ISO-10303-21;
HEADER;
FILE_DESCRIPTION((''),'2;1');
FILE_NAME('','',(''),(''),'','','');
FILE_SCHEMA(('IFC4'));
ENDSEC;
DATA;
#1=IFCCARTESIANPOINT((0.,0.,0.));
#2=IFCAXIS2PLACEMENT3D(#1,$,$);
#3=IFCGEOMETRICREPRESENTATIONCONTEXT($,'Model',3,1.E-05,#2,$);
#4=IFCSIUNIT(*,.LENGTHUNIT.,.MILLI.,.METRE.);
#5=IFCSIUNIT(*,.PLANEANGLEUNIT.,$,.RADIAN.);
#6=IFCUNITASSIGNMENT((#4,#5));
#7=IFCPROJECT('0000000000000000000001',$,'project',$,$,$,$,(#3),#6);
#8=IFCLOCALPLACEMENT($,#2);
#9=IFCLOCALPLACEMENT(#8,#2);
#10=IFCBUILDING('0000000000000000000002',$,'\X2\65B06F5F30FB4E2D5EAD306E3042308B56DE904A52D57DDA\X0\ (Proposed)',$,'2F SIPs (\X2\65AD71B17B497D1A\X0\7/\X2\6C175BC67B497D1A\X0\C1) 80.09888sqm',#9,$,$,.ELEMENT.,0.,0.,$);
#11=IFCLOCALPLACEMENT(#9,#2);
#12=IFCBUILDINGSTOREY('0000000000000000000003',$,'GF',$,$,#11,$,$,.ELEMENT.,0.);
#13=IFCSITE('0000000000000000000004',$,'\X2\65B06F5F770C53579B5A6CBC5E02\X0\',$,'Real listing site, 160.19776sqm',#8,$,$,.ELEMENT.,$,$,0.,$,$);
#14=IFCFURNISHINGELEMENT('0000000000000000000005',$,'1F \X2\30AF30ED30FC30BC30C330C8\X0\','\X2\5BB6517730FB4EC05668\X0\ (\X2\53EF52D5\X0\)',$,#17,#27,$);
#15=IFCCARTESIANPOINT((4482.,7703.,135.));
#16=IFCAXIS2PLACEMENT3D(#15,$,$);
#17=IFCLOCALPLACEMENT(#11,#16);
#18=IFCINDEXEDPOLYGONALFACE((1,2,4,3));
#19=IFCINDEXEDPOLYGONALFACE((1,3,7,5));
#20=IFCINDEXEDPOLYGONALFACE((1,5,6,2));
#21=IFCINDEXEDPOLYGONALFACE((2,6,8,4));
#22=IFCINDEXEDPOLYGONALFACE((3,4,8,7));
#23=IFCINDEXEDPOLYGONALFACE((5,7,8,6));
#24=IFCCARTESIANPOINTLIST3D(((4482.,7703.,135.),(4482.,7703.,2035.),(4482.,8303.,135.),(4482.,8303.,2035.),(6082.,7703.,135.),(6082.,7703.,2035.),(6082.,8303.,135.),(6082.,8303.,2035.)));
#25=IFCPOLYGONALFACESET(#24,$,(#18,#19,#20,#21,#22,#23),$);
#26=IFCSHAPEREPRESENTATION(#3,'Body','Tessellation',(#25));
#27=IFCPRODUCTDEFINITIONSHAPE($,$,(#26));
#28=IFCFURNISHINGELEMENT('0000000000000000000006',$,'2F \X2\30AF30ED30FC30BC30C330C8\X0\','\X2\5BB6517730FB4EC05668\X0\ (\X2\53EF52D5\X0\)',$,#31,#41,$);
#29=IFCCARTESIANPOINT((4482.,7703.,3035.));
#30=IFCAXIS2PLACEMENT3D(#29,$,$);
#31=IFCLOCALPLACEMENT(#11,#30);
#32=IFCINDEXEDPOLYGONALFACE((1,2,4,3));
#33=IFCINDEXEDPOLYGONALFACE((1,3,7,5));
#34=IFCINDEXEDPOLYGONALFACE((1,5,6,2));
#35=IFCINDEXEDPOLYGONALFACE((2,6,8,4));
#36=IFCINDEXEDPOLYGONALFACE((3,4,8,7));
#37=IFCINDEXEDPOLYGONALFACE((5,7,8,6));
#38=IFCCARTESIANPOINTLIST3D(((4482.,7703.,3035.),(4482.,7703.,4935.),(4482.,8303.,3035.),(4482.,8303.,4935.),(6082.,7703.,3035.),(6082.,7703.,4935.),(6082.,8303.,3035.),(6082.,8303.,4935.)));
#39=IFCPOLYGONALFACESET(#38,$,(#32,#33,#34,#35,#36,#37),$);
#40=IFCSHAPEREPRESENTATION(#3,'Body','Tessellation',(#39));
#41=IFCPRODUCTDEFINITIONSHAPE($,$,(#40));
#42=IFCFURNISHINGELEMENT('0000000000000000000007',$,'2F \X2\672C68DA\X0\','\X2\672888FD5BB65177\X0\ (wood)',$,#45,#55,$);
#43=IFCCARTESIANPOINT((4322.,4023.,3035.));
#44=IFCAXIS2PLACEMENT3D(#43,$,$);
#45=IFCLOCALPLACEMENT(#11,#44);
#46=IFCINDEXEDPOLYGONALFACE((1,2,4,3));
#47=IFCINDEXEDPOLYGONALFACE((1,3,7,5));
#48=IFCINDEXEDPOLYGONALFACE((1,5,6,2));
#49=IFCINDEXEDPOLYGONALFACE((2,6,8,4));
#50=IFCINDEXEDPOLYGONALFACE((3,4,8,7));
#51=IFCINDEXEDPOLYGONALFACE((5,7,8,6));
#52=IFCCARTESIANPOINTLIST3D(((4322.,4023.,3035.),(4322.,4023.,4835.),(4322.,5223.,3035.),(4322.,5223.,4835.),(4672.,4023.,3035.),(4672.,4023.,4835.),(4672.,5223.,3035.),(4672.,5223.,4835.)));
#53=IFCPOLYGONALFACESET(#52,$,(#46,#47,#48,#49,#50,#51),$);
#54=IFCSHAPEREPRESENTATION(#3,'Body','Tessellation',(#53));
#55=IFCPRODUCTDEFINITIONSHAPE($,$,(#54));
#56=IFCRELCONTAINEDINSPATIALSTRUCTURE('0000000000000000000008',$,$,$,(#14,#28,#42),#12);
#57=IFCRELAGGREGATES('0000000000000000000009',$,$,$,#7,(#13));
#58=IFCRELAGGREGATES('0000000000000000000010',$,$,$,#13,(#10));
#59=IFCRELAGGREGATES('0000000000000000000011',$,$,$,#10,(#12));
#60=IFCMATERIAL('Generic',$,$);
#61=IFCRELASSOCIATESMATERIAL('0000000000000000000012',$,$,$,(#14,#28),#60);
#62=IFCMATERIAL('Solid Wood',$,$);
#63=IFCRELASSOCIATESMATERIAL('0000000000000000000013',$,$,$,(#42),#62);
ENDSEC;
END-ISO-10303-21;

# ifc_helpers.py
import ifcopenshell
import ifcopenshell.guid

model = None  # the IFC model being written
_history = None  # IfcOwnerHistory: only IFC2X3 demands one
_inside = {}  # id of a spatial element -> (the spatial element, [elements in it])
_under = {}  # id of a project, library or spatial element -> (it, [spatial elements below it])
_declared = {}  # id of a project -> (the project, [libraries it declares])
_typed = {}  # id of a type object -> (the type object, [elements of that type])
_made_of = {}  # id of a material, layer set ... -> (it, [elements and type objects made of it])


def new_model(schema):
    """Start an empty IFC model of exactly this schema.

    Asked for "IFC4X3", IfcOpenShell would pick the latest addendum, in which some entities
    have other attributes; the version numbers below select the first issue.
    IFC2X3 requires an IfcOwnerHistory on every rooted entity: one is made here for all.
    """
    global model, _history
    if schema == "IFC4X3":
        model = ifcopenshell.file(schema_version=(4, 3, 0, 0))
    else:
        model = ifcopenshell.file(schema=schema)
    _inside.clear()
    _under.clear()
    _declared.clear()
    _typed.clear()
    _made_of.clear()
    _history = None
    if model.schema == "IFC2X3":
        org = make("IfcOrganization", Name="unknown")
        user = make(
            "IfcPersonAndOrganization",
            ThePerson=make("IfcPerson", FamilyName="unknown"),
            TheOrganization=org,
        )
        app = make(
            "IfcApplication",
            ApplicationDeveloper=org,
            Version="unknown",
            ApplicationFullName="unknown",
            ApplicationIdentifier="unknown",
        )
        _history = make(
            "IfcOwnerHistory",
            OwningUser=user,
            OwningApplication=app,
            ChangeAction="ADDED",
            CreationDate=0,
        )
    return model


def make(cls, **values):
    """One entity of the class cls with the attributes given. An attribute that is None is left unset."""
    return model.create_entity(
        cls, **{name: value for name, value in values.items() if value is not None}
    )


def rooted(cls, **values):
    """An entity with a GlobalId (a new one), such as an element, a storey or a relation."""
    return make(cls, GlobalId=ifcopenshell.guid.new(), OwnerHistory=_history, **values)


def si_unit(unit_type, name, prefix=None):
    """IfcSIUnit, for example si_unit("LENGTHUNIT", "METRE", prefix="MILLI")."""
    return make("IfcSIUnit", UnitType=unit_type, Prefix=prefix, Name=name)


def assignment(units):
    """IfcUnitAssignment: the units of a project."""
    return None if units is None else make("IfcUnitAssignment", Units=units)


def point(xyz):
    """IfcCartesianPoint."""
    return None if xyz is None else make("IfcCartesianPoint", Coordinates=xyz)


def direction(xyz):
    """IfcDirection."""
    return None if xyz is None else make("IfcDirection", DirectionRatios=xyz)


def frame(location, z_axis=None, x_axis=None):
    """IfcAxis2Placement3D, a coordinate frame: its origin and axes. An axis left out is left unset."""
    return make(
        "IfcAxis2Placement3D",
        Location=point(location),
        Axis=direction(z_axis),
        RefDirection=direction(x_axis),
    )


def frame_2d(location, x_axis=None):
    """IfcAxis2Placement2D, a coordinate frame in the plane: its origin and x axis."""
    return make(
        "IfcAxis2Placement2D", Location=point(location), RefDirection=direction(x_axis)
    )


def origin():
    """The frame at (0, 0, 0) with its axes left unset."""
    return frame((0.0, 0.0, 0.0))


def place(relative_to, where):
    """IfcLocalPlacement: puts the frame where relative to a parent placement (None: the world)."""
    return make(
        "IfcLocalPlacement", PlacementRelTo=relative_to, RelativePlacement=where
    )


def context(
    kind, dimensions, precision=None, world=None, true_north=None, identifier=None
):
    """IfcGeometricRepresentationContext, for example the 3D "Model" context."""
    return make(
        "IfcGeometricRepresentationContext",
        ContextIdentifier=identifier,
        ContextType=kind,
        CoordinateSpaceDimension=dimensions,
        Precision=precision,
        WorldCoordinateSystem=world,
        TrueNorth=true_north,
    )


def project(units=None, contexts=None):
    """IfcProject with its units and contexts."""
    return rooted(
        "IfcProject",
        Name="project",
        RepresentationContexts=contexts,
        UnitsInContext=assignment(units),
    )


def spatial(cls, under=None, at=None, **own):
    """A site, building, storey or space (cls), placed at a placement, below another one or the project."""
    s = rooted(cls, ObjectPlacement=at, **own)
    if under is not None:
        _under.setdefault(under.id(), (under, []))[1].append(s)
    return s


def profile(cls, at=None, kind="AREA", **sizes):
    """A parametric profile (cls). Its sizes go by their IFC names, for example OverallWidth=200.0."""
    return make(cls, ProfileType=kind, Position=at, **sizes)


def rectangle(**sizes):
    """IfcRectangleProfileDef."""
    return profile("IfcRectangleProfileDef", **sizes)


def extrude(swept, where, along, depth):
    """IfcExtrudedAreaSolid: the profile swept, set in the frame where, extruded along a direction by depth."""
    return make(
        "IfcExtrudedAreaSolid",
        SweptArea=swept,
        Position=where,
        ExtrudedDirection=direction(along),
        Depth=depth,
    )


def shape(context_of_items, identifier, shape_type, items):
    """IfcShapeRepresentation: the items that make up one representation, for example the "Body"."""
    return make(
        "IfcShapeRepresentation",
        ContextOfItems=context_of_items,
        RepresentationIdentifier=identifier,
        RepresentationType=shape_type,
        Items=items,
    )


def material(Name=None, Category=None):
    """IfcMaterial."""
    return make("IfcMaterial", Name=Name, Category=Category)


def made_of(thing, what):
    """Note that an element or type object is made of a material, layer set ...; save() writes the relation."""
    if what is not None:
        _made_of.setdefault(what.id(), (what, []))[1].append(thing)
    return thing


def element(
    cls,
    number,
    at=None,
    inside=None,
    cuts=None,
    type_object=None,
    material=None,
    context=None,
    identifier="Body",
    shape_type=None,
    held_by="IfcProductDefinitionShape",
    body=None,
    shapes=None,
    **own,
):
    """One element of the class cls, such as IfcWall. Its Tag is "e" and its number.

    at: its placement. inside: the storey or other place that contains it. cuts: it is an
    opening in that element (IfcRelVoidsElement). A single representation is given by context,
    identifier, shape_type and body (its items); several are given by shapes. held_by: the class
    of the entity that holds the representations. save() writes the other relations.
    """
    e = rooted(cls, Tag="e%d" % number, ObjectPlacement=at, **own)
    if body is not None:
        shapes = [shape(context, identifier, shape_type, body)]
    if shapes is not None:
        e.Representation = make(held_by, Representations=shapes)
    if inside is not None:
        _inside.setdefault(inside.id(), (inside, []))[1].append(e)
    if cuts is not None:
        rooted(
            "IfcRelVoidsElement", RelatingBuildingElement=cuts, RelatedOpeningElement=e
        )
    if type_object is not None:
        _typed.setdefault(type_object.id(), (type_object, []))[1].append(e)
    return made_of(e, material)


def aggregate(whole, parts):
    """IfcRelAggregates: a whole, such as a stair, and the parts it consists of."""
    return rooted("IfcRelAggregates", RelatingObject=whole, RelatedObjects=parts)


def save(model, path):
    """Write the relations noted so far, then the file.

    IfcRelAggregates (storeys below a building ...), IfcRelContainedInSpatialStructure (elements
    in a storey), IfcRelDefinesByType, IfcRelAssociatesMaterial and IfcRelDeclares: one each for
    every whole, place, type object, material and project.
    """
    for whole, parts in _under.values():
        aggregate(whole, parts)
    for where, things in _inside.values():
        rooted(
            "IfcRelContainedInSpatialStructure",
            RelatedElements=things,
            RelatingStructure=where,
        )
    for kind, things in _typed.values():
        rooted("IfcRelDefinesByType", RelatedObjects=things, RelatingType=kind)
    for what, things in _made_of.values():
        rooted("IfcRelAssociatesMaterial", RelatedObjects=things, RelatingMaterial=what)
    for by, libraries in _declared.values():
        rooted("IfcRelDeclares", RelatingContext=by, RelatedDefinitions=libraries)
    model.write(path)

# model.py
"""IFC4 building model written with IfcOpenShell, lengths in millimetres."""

from ifc_helpers import new_model, si_unit, frame, frame_2d, origin, place, context, project, spatial, rectangle, extrude, material, element, save


model = new_model("IFC4")

# Units and contexts
model_context = context("Model", 3, precision=1e-05, world=origin())
ifc_project = project(units=[si_unit("LENGTHUNIT", "METRE", prefix="MILLI"), si_unit("PLANEANGLEUNIT", "RADIAN")], contexts=[model_context])

# Site, building, storey
site_placement = place(None, origin())
site = spatial("IfcSite", under=ifc_project, at=site_placement, Name="新潟県南魚沼市", ObjectType="Real listing site, 160.19776sqm", CompositionType="ELEMENT", RefElevation=0.0)
building_placement = place(site_placement, origin())
building = spatial("IfcBuilding", under=site, at=building_placement, Name="新潟・中庭のある回遊動線 (Proposed)", ObjectType="2F SIPs (断熱等級7/気密等級C1) 80.09888sqm", CompositionType="ELEMENT", ElevationOfRefHeight=0.0, ElevationOfTerrain=0.0)
storey_placement = place(building_placement, origin())
storey = spatial("IfcBuildingStorey", under=building, at=storey_placement, Name="GF", CompositionType="ELEMENT", Elevation=0.0)

# Shared definitions
ifc_material_1 = material(Name="Solid Wood")

# Shared definitions
ifc_material_2 = material(Name="Generic")

# Furnishing elements
furnishing_1_placement = place(storey_placement, frame((4482.0, 7703.0, 135.0)))
element("IfcFurnishingElement", 1, at=furnishing_1_placement, inside=storey, material=ifc_material_2, Name="1F クローゼット", Description="家具・什器 (可動)", context=model_context, shape_type="SweptSolid", body=[
    extrude(rectangle(XDim=1600.0, YDim=600.0, at=frame_2d((800.0, 300.0))), frame((4482.0, 7703.0, 135.0)), (0.0, 0.0, 1.0), 1900.0),
])
furnishing_2_placement = place(storey_placement, frame((4482.0, 7703.0, 3035.0)))
element("IfcFurnishingElement", 2, at=furnishing_2_placement, inside=storey, material=ifc_material_2, Name="2F クローゼット", Description="家具・什器 (可動)", context=model_context, shape_type="SweptSolid", body=[
    extrude(rectangle(XDim=1600.0, YDim=600.0, at=frame_2d((800.0, 300.0))), frame((4482.0, 7703.0, 3035.0)), (0.0, 0.0, 1.0), 1900.0),
])
furnishing_3_placement = place(storey_placement, frame((4322.0, 4023.0, 3035.0)))
element("IfcFurnishingElement", 3, at=furnishing_3_placement, inside=storey, material=ifc_material_1, Name="2F 本棚", Description="木製家具 (wood)", context=model_context, shape_type="SweptSolid", body=[
    extrude(rectangle(XDim=350.0, YDim=1200.0, at=frame_2d((175.0, 600.0))), frame((4322.0, 4023.0, 3035.0)), (0.0, 0.0, 1.0), 1800.0),
])

save(model, "model.ifc")
